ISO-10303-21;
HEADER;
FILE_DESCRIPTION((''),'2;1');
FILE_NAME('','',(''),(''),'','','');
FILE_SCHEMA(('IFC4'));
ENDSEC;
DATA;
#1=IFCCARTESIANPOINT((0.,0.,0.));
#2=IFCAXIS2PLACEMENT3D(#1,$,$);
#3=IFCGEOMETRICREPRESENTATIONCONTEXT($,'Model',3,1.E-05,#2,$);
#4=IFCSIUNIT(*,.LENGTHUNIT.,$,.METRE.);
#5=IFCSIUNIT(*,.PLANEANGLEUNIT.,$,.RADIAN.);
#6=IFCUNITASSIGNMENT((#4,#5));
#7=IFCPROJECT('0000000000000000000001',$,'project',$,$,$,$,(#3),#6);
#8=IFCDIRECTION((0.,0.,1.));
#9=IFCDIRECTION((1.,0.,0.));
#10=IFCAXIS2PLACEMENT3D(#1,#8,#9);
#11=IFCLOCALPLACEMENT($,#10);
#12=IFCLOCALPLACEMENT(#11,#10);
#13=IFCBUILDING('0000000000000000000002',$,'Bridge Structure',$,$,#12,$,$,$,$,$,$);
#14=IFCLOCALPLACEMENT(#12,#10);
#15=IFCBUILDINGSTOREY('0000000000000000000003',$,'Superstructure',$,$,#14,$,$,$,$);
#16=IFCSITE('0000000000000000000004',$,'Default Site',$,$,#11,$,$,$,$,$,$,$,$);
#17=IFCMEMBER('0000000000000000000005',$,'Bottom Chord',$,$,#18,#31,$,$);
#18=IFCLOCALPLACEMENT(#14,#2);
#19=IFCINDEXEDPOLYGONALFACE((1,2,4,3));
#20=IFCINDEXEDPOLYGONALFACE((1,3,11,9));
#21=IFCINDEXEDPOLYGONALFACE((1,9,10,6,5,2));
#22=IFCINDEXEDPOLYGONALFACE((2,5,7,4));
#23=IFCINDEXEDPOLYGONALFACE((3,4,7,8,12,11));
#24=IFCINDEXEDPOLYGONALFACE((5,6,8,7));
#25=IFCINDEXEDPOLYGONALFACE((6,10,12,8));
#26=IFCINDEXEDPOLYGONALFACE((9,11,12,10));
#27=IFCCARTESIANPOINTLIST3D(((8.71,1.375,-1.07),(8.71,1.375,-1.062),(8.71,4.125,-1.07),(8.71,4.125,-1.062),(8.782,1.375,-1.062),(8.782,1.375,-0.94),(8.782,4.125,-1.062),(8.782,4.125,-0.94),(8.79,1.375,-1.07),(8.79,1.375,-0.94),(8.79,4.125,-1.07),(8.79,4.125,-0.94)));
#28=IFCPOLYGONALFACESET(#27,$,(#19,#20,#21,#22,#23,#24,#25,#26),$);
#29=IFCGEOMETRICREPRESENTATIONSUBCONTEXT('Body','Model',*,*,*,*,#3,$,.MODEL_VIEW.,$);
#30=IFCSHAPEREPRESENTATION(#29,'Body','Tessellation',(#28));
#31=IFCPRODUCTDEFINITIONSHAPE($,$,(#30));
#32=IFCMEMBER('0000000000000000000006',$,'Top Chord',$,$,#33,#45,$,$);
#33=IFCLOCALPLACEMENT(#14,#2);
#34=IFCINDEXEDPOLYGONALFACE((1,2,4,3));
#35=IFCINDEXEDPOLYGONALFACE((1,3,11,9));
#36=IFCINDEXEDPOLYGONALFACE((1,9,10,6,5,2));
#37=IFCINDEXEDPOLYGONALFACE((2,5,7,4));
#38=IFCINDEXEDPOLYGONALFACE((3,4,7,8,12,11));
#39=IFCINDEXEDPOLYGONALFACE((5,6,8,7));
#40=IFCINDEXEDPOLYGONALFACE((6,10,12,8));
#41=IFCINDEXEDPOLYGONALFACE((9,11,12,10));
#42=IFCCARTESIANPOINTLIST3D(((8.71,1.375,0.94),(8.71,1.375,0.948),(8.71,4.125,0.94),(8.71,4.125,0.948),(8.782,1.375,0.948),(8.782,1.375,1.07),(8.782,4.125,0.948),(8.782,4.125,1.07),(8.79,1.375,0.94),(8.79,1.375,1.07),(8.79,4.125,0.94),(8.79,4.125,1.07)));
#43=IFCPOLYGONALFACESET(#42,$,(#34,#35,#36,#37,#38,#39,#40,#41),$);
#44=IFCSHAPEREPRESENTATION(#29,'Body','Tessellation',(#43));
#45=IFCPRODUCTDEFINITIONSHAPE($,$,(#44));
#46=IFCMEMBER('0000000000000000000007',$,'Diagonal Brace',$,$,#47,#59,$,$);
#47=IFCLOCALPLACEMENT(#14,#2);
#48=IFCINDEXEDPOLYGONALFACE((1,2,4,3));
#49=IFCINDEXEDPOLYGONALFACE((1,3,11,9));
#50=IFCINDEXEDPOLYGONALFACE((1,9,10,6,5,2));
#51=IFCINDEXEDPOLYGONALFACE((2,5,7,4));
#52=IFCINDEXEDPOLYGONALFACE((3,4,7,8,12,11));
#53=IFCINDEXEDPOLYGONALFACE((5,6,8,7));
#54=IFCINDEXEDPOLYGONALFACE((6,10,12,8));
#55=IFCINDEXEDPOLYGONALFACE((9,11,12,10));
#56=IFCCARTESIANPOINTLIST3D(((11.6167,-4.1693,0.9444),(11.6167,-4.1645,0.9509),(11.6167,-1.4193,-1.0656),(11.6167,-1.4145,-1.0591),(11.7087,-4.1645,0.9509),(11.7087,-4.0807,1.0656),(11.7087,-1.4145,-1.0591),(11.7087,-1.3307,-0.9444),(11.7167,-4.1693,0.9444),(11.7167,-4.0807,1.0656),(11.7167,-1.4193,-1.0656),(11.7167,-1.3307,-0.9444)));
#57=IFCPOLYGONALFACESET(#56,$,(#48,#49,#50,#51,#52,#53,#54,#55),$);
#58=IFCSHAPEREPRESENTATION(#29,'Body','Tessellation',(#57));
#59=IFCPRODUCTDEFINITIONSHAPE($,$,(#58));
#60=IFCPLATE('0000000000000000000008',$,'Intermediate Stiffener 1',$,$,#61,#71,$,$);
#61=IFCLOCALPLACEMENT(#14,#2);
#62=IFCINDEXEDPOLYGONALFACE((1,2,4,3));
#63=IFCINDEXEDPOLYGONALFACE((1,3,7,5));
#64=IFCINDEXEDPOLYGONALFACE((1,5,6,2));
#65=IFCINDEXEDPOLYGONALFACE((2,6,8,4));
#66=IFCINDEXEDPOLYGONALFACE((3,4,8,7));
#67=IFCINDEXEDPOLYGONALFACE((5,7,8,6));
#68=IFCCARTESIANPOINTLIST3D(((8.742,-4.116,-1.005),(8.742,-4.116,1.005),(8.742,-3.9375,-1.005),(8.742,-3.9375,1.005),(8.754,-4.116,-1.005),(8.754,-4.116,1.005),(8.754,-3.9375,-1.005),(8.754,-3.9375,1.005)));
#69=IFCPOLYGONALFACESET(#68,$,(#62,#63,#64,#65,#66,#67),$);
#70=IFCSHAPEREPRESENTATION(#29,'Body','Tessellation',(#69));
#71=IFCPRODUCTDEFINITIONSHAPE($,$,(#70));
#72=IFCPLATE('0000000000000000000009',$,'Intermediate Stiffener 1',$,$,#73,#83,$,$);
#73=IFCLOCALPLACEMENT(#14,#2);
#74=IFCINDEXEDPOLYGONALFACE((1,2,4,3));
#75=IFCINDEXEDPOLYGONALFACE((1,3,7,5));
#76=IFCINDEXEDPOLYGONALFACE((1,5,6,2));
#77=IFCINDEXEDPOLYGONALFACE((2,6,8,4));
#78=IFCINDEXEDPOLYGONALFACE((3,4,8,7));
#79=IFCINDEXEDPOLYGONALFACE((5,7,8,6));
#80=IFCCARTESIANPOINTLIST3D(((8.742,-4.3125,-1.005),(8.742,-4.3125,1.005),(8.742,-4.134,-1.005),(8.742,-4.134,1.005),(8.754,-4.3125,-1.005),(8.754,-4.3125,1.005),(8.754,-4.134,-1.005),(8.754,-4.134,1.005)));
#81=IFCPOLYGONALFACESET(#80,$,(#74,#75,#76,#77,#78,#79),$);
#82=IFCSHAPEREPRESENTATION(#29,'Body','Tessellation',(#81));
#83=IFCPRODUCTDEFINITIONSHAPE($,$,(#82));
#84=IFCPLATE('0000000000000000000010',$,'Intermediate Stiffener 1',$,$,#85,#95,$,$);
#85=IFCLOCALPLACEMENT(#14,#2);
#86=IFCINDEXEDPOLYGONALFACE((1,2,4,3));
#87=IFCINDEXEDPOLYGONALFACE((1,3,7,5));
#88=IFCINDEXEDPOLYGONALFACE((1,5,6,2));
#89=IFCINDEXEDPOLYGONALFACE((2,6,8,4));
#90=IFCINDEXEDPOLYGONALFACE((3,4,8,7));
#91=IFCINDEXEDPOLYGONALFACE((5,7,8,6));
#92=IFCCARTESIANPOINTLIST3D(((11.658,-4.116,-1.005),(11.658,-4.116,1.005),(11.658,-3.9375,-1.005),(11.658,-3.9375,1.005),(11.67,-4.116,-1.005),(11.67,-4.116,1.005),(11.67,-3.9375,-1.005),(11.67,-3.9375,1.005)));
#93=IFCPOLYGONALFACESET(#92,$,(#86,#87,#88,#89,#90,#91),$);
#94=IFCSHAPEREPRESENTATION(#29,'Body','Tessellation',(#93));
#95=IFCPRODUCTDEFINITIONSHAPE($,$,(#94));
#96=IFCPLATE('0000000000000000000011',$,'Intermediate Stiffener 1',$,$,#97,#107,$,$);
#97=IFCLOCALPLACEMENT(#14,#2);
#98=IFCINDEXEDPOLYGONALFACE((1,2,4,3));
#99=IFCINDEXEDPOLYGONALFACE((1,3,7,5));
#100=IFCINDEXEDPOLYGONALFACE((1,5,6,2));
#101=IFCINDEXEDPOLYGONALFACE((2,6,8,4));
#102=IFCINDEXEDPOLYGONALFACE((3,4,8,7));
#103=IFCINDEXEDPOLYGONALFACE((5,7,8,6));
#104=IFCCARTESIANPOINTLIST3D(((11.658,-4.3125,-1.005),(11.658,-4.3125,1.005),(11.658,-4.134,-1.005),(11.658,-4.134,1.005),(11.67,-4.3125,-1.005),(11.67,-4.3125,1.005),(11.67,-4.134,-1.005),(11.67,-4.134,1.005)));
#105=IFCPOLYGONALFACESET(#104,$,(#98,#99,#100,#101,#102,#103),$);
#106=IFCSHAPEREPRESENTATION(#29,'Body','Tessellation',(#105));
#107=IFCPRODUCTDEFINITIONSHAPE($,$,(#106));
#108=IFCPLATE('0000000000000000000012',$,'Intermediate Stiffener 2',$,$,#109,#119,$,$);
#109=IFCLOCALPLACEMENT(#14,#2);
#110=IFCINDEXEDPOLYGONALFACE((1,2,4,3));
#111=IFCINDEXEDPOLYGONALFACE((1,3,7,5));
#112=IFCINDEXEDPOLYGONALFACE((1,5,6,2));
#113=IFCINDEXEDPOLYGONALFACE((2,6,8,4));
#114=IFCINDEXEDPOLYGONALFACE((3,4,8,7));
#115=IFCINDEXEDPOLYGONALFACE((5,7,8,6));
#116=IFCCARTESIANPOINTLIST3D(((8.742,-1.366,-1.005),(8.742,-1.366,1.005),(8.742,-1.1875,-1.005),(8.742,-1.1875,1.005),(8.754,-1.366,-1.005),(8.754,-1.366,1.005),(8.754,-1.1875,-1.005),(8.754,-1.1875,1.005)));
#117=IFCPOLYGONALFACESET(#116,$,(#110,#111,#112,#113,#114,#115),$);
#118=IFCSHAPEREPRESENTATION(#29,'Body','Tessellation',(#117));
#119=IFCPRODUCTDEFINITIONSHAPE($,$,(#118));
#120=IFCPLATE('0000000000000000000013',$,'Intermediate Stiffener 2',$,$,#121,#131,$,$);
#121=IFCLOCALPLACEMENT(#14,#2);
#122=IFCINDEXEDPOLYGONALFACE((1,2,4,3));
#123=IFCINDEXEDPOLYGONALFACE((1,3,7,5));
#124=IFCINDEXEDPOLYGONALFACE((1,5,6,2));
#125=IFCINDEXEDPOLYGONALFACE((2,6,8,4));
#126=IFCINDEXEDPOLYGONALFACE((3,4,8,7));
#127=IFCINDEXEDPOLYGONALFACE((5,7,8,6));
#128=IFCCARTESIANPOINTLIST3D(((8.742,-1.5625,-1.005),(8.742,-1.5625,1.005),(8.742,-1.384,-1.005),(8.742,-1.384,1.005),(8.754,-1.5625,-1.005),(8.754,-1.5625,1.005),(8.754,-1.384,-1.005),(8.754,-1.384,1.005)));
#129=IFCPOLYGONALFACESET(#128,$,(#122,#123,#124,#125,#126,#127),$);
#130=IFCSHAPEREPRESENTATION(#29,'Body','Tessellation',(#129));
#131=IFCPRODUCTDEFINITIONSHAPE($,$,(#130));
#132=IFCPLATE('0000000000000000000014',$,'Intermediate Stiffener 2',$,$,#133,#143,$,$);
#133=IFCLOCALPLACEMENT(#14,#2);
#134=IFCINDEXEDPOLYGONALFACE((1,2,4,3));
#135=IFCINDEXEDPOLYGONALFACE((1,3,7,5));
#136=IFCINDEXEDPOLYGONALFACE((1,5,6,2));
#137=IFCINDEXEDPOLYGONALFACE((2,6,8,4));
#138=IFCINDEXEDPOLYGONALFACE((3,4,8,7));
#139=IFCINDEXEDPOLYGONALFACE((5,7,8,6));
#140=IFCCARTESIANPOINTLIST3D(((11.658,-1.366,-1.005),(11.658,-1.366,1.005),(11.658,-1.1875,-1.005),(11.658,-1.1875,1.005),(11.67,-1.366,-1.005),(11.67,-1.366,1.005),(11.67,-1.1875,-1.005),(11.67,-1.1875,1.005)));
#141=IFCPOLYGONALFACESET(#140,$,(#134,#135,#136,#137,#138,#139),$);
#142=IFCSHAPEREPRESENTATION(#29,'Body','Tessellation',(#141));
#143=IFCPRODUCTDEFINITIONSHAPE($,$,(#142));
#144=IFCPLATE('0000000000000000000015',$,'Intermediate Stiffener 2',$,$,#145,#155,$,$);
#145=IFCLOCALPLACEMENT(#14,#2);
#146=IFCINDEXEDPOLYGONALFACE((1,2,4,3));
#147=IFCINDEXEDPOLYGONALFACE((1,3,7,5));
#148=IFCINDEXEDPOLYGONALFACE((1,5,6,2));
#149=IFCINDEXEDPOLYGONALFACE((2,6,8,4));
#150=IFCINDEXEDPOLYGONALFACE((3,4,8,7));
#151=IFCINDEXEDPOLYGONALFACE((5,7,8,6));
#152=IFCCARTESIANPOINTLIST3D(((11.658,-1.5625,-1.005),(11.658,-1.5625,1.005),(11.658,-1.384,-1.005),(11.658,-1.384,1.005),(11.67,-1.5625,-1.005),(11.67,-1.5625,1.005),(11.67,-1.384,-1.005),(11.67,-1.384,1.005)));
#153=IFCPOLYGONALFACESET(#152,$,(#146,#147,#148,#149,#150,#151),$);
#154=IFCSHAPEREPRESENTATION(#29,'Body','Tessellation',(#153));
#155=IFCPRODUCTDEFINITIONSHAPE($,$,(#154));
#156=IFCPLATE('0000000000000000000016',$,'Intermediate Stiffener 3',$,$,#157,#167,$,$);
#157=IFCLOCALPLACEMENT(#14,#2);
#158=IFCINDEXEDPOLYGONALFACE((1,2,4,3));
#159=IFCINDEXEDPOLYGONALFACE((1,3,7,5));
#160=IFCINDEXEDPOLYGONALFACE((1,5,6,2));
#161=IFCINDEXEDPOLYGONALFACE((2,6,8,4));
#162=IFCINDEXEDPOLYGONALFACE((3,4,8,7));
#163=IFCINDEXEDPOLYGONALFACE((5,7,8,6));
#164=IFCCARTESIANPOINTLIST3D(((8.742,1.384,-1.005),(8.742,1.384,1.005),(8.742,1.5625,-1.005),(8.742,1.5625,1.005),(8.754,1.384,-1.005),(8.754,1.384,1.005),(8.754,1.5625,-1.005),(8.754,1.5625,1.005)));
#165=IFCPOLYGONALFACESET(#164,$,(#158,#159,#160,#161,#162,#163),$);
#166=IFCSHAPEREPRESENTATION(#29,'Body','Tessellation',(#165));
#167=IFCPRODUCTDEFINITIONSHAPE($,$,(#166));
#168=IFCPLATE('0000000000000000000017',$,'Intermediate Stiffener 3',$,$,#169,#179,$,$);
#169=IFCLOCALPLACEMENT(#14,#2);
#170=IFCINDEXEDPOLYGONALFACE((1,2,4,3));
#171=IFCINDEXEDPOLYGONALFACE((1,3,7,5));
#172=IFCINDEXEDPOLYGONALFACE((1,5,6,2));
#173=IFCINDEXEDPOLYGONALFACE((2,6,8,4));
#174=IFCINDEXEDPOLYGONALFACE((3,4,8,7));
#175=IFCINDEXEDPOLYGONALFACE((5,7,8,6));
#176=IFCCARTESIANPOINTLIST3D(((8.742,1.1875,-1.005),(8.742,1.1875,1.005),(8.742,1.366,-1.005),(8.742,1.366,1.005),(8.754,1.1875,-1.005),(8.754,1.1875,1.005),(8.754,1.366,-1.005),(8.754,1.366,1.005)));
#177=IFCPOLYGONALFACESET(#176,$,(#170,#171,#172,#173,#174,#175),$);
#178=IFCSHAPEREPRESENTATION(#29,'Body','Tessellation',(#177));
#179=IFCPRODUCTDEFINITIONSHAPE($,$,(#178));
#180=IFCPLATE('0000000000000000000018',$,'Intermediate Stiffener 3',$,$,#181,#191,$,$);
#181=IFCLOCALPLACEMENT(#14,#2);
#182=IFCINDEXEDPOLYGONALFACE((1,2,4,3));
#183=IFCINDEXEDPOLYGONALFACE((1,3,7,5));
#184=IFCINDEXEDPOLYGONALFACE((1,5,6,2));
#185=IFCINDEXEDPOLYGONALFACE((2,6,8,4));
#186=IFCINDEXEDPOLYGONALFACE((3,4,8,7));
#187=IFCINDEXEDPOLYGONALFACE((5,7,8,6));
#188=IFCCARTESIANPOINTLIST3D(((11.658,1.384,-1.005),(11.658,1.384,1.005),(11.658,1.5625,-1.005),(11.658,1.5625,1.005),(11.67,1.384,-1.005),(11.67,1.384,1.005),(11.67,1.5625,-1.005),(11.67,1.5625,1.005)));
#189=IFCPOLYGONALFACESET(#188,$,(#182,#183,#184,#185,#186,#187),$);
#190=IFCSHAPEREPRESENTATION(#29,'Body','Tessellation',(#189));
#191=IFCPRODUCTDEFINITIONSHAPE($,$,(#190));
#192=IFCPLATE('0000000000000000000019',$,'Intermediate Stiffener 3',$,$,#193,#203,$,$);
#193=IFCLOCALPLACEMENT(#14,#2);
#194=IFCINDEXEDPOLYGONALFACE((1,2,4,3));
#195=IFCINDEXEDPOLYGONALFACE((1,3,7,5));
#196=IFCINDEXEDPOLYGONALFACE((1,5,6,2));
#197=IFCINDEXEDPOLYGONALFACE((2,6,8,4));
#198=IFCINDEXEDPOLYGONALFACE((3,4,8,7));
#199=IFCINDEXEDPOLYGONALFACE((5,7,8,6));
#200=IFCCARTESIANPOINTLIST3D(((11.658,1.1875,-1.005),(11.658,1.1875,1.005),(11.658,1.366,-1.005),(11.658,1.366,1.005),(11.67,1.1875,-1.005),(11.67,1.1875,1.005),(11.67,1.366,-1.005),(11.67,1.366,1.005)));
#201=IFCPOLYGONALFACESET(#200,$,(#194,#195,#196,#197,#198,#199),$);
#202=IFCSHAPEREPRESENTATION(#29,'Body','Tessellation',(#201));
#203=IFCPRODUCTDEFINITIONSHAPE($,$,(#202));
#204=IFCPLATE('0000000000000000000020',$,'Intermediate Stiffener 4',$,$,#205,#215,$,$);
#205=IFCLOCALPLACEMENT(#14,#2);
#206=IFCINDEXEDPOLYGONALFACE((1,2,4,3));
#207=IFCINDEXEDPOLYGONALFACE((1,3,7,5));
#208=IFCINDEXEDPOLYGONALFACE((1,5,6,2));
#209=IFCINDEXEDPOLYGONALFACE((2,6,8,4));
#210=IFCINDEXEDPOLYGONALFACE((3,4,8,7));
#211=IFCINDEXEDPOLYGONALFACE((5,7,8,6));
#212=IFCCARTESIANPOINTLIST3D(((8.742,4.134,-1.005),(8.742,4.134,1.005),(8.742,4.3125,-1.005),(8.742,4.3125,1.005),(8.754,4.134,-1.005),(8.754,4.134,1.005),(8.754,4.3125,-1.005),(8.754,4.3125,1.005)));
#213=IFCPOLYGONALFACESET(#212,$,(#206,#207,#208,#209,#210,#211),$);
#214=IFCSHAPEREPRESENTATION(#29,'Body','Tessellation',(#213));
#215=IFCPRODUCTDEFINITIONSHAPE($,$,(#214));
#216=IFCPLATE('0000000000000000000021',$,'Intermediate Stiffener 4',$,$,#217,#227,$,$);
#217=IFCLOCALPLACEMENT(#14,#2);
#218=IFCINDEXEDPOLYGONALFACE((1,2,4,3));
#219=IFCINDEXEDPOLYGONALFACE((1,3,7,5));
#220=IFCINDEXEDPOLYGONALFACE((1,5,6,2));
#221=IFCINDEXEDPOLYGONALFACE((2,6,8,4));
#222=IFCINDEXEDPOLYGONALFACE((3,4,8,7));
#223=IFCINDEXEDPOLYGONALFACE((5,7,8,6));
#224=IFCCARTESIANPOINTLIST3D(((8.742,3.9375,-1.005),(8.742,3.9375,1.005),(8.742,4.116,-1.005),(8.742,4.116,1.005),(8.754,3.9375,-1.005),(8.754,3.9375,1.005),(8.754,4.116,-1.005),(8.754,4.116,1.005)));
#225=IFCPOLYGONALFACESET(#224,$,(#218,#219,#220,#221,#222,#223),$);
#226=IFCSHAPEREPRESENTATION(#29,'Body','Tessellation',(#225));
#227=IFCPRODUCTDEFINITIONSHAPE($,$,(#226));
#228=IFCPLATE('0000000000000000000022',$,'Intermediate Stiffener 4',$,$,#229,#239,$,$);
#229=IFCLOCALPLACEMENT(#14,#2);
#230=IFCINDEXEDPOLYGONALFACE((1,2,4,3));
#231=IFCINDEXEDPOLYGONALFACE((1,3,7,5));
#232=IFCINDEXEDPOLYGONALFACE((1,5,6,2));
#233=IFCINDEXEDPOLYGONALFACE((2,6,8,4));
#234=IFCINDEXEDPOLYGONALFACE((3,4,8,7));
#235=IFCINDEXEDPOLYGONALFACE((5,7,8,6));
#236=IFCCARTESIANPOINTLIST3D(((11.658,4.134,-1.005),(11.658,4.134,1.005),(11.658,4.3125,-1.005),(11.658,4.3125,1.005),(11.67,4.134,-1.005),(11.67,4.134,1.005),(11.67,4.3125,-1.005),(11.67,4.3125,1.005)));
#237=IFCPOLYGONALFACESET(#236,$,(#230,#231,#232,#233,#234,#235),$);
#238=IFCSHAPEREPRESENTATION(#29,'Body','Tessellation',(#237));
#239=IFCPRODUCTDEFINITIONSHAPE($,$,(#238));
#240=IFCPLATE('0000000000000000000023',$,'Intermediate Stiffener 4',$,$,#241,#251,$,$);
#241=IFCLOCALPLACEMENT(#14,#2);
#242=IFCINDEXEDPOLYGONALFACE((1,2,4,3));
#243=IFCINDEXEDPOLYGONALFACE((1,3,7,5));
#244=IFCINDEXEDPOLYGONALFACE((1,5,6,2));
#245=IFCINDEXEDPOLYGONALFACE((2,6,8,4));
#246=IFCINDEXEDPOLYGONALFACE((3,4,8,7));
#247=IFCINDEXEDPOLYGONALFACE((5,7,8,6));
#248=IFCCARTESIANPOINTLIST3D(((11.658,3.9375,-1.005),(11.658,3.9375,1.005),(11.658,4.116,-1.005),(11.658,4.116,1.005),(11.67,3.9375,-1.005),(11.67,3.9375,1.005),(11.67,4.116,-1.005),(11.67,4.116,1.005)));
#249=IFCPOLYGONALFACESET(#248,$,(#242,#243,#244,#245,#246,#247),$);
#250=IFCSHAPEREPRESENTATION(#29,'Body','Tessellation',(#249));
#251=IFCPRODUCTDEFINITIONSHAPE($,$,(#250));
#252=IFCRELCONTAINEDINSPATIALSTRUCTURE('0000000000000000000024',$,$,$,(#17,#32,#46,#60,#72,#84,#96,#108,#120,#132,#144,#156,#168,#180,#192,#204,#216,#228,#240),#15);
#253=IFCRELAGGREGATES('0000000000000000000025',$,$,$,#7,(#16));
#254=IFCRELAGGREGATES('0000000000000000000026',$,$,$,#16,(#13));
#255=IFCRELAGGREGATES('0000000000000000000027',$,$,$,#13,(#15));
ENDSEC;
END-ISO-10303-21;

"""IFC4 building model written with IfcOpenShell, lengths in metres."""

from ifc_helpers import new_model, si_unit, frame, origin, origin_with_axes, origin_2d_with_axis, place, context, subcontext, project, spatial, rectangle, l_section, extrude, element, save


model = new_model("IFC4")

# Units and contexts
model_context = context("Model", 3, precision=1e-05, world=origin())
body_context = subcontext(model_context, "Body", "Model", "MODEL_VIEW")
ifc_project = project(units=[si_unit("LENGTHUNIT", "METRE"), si_unit("PLANEANGLEUNIT", "RADIAN")], contexts=[model_context])

# Site, building, storey
site_placement = place(None, origin_with_axes())
site = spatial("IfcSite", under=ifc_project, at=site_placement, Name="Default Site")
building_placement = place(site_placement, origin_with_axes())
building = spatial("IfcBuilding", under=site, at=building_placement, Name="Bridge Structure")
storey_placement = place(building_placement, origin_with_axes())
storey = spatial("IfcBuildingStorey", under=building, at=storey_placement, Name="Superstructure")

# Members
for number, where, z_axis, x_axis, name in (
    (1, (8.75, 1.375, -1.005), (0.0, 1.0, 0.0), (-1.0, 0.0, 0.0), "Bottom Chord"),
    (2, (8.75, 1.375, 1.005), (0.0, 1.0, 0.0), (-1.0, 0.0, 0.0), "Top Chord"),
):
    element("IfcMember", number, at=place(storey_placement, frame(where, z_axis=z_axis, x_axis=x_axis)), inside=storey, Name=name, context=body_context, shape_type="SweptSolid", body=[
        extrude(l_section(Depth=0.13, Width=0.08, Thickness=0.008, at=origin_2d_with_axis()), origin_with_axes(), (0.0, 0.0, 1.0), 2.75),
    ])
member_1_placement = place(storey_placement, frame((11.6667, -4.125, 1.005), z_axis=(0.0, 0.807337, -0.59009), x_axis=(-1.0, 0.0, 0.0)))
element("IfcMember", 3, at=member_1_placement, inside=storey, Name="Diagonal Brace", context=body_context, shape_type="SweptSolid", body=[
    extrude(l_section(Depth=0.15, Width=0.1, Thickness=0.008, at=origin_2d_with_axis()), origin_with_axes(), (0.0, 0.0, 1.0), 3.4063),
])

# Plates
for number, where, z_axis, x_axis, name in (
    (4, (8.748, -4.0267, -1.005), (0.0, 0.0, 1.0), (1.0, 0.0, 0.0), "Intermediate Stiffener 1"),
    (5, (8.748, -4.2233, -1.005), (0.0, 0.0, 1.0), (1.0, 0.0, 0.0), "Intermediate Stiffener 1"),
    (6, (11.664, -4.0267, -1.005), (0.0, 0.0, 1.0), (1.0, 0.0, 0.0), "Intermediate Stiffener 1"),
    (7, (11.664, -4.2233, -1.005), (0.0, 0.0, 1.0), (1.0, 0.0, 0.0), "Intermediate Stiffener 1"),
    (8, (8.748, -1.2768, -1.005), (0.0, 0.0, 1.0), (1.0, 0.0, 0.0), "Intermediate Stiffener 2"),
    (9, (8.748, -1.4732, -1.005), (0.0, 0.0, 1.0), (1.0, 0.0, 0.0), "Intermediate Stiffener 2"),
    (10, (11.664, -1.2768, -1.005), (0.0, 0.0, 1.0), (1.0, 0.0, 0.0), "Intermediate Stiffener 2"),
    (11, (11.664, -1.4732, -1.005), (0.0, 0.0, 1.0), (1.0, 0.0, 0.0), "Intermediate Stiffener 2"),
    (12, (8.748, 1.4732, -1.005), (0.0, 0.0, 1.0), (1.0, 0.0, 0.0), "Intermediate Stiffener 3"),
    (13, (8.748, 1.2768, -1.005), (0.0, 0.0, 1.0), (1.0, 0.0, 0.0), "Intermediate Stiffener 3"),
    (14, (11.664, 1.4732, -1.005), (0.0, 0.0, 1.0), (1.0, 0.0, 0.0), "Intermediate Stiffener 3"),
    (15, (11.664, 1.2768, -1.005), (0.0, 0.0, 1.0), (1.0, 0.0, 0.0), "Intermediate Stiffener 3"),
    (16, (8.748, 4.2233, -1.005), (0.0, 0.0, 1.0), (1.0, 0.0, 0.0), "Intermediate Stiffener 4"),
    (17, (8.748, 4.0267, -1.005), (0.0, 0.0, 1.0), (1.0, 0.0, 0.0), "Intermediate Stiffener 4"),
    (18, (11.664, 4.2233, -1.005), (0.0, 0.0, 1.0), (1.0, 0.0, 0.0), "Intermediate Stiffener 4"),
    (19, (11.664, 4.0267, -1.005), (0.0, 0.0, 1.0), (1.0, 0.0, 0.0), "Intermediate Stiffener 4"),
):
    element("IfcPlate", number, at=place(storey_placement, frame(where, z_axis=z_axis, x_axis=x_axis)), inside=storey, Name=name, context=body_context, shape_type="SweptSolid", body=[
        extrude(rectangle(XDim=0.012, YDim=0.1785, at=origin_2d_with_axis()), origin_with_axes(), (0.0, 0.0, 1.0), 2.01),
    ])

save(model, "model.ifc")
